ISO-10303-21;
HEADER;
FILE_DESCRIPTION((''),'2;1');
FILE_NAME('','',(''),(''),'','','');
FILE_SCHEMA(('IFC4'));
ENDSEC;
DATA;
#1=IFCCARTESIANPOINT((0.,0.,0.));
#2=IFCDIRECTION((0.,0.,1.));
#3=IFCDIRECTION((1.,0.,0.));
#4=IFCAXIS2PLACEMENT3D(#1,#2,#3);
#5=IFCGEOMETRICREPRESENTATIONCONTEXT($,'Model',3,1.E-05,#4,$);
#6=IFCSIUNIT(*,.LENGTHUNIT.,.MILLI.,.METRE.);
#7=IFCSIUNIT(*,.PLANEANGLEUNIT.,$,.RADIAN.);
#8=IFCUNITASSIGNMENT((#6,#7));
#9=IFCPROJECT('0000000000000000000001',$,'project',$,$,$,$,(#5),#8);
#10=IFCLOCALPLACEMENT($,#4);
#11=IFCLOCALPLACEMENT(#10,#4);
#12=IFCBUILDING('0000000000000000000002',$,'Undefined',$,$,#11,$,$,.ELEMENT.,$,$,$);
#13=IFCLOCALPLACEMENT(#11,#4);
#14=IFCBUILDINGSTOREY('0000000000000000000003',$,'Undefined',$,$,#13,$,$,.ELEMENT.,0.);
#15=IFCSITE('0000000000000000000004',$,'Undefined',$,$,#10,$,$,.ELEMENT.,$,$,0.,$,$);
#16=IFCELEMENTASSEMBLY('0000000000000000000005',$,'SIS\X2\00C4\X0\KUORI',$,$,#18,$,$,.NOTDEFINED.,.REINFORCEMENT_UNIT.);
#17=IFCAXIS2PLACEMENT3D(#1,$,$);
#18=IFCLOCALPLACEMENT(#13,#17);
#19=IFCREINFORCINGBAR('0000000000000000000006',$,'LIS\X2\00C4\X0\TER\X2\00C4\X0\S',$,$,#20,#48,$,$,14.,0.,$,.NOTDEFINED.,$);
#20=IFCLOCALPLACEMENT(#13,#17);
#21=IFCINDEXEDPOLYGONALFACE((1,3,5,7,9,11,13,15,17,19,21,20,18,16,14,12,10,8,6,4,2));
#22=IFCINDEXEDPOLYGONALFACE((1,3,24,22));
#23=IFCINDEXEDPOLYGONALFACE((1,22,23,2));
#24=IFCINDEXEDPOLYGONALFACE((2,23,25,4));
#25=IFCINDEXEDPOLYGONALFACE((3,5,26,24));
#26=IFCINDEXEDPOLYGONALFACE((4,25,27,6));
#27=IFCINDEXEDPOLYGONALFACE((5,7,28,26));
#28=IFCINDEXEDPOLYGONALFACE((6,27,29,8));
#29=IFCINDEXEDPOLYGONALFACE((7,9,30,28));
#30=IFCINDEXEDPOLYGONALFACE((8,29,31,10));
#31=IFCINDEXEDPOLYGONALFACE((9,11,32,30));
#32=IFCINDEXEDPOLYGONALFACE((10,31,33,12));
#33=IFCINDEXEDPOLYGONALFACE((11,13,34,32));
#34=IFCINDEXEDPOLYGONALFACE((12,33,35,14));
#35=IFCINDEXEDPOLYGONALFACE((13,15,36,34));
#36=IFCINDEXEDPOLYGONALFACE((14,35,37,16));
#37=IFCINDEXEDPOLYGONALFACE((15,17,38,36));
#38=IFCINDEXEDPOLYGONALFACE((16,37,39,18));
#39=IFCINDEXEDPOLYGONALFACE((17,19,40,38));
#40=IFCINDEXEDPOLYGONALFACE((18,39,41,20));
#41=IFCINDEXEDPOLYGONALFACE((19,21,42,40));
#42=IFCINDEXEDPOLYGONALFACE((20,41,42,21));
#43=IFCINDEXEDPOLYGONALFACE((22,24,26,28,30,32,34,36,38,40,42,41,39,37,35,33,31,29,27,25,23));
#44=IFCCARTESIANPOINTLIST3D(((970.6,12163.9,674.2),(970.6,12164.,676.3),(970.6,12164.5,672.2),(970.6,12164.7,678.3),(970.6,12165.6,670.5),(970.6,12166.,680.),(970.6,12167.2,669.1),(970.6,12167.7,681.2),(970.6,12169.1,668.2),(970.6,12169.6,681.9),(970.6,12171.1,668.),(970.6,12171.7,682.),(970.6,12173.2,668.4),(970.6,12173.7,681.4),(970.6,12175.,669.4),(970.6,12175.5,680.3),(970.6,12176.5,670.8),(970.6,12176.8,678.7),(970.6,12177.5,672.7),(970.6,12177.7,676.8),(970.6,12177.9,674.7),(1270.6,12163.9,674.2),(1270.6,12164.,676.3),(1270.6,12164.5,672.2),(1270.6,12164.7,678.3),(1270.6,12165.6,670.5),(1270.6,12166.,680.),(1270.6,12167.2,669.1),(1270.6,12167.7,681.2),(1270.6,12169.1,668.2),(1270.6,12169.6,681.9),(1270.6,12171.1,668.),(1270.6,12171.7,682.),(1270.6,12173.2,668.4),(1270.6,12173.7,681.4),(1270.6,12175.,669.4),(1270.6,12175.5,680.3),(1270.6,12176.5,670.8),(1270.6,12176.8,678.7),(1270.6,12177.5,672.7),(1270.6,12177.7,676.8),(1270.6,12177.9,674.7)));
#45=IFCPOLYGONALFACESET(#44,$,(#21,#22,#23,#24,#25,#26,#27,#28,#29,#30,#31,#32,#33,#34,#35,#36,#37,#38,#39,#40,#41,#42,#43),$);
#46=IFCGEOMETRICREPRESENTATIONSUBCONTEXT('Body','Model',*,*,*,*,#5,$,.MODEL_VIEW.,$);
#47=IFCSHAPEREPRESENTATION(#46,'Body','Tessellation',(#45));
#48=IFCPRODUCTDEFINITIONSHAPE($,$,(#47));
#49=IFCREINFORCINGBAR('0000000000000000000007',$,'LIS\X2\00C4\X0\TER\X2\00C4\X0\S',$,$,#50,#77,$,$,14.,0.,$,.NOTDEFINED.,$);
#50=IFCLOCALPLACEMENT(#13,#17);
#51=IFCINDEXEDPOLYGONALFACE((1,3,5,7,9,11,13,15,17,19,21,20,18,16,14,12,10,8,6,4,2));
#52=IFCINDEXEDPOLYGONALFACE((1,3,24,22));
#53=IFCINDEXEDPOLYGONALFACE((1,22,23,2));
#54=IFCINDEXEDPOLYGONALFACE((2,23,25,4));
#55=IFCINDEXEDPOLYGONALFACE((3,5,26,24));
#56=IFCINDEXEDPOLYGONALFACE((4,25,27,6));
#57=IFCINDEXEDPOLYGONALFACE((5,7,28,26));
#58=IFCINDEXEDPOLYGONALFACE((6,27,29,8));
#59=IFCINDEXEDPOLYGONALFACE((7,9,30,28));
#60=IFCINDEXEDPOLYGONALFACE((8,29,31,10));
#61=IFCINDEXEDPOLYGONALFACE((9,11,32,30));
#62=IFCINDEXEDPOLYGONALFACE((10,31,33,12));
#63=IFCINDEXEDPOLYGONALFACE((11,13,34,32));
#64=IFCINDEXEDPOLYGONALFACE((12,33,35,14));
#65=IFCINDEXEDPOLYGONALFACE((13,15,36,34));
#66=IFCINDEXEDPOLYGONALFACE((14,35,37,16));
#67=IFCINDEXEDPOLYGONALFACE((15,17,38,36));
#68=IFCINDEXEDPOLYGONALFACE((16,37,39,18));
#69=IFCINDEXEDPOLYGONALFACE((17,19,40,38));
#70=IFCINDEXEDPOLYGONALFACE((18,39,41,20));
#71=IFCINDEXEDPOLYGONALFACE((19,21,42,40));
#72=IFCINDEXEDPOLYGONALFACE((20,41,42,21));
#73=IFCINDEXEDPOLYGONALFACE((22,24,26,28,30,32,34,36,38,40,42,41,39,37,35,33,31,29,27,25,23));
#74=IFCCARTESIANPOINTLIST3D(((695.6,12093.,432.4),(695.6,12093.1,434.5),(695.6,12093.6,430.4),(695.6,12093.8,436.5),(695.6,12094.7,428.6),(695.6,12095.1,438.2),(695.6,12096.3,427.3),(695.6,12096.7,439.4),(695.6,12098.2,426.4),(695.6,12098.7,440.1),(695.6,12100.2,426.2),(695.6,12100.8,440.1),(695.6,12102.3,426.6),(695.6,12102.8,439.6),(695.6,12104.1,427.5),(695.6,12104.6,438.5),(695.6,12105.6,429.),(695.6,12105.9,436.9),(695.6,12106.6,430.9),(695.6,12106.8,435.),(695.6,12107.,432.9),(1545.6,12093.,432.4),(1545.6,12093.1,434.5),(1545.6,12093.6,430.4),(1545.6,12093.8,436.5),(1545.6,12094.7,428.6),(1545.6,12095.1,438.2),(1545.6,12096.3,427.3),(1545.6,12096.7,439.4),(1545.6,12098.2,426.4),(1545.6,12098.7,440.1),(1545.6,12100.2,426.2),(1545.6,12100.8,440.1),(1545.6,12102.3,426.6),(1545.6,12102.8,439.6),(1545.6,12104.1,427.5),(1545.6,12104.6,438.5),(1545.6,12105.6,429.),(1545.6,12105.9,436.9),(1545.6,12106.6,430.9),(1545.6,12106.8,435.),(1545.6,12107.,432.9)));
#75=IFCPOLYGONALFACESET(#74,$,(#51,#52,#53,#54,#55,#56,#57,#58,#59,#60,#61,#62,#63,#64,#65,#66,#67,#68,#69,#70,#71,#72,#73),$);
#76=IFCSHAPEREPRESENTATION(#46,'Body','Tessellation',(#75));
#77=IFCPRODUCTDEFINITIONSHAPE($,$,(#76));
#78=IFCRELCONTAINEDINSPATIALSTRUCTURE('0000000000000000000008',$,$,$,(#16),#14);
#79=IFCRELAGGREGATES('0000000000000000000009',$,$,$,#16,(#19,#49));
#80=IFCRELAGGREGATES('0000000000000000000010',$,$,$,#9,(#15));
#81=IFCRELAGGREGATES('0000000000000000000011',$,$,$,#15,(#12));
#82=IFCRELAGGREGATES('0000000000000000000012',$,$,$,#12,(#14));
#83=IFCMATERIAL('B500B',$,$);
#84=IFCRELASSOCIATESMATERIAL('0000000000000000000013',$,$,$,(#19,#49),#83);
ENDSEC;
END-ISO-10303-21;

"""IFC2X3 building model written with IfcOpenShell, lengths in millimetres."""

from ifc_helpers import new_model, entity, si_unit, frame, origin_with_axes, place, context, subcontext, project, spatial, source, transform, mapped, material, element, aggregate, save


model = new_model("IFC2X3")

# Units and contexts
model_context = context("Model", 3, precision=1e-05, world=origin_with_axes())
body_context = subcontext(model_context, "Body", "Model", "MODEL_VIEW")
ifc_project = project(units=[si_unit("LENGTHUNIT", "METRE", prefix="MILLI"), si_unit("PLANEANGLEUNIT", "RADIAN")], contexts=[model_context])

# Site, building, storey
site_placement = place(None, origin_with_axes())
site = spatial("IfcSite", under=ifc_project, at=site_placement, Name="Undefined", CompositionType="ELEMENT", RefElevation=0.0)
building_placement = place(site_placement, origin_with_axes())
building = spatial("IfcBuilding", under=site, at=building_placement, Name="Undefined", CompositionType="ELEMENT")
storey_placement = place(building_placement, origin_with_axes())
storey = spatial("IfcBuildingStorey", under=building, at=storey_placement, Name="Undefined", CompositionType="ELEMENT", Elevation=0.0)

# Element assembly
assembly_1_placement = place(storey_placement, origin_with_axes())
assembly_1 = element("IfcElementAssembly", 1, at=assembly_1_placement, inside=storey, Name="SISÄKUORI", AssemblyPlace="NOTDEFINED", PredefinedType="REINFORCEMENT_UNIT")

# Reinforcing bars
ifc_material_1 = material(Name="B500B")
shared_shape_1 = source(origin_with_axes(), body_context, "Body", "AdvancedSweptSolid", [
    entity("IfcSweptDiskSolid", entity("IfcTrimmedCurve", entity("IfcLine", entity("IfcCartesianPoint", [0.0, 0.0, 0.0]), entity("IfcVector", entity("IfcDirection", [1.0, 0.0, 0.0]), 1.0)), [entity("IfcParameterValue", 0.0)], [entity("IfcParameterValue", 300.0)], True, "PARAMETER"), 7.0, None, 0.0, 300.0),
])
reinforcing_bar_1_placement = place(assembly_1_placement, frame((970.6, 12170.9, 675.0), z_axis=(0.0, 0.034142, -0.999417), x_axis=(1.0, 0.0, 0.0)))
reinforcing_bar_1 = element("IfcReinforcingBar", 2, at=reinforcing_bar_1_placement, material=ifc_material_1, Name="LISÄTERÄS", BarRole="NOTDEFINED", CrossSectionArea=0.0, NominalDiameter=14.0, context=body_context, shape_type="MappedRepresentation", body=[
    mapped(shared_shape_1, transform((0.0, 0.0, 0.0))),
])
shared_shape_2 = source(origin_with_axes(), body_context, "Body", "AdvancedSweptSolid", [
    entity("IfcSweptDiskSolid", entity("IfcTrimmedCurve", entity("IfcLine", entity("IfcCartesianPoint", [0.0, 0.0, 0.0]), entity("IfcVector", entity("IfcDirection", [1.0, 0.0, 0.0]), 1.0)), [entity("IfcParameterValue", 0.0)], [entity("IfcParameterValue", 850.0)], True, "PARAMETER"), 7.0, None, 0.0, 850.0),
])
reinforcing_bar_2_placement = place(assembly_1_placement, frame((695.6, 12100.0, 433.2), z_axis=(0.0, 0.034142, -0.999417), x_axis=(1.0, 0.0, 0.0)))
reinforcing_bar_2 = element("IfcReinforcingBar", 3, at=reinforcing_bar_2_placement, material=ifc_material_1, Name="LISÄTERÄS", BarRole="NOTDEFINED", CrossSectionArea=0.0, NominalDiameter=14.0, context=body_context, shape_type="MappedRepresentation", body=[
    mapped(shared_shape_2, transform((0.0, 0.0, 0.0))),
])
aggregate(assembly_1, [reinforcing_bar_1, reinforcing_bar_2])

save(model, "model.ifc")
